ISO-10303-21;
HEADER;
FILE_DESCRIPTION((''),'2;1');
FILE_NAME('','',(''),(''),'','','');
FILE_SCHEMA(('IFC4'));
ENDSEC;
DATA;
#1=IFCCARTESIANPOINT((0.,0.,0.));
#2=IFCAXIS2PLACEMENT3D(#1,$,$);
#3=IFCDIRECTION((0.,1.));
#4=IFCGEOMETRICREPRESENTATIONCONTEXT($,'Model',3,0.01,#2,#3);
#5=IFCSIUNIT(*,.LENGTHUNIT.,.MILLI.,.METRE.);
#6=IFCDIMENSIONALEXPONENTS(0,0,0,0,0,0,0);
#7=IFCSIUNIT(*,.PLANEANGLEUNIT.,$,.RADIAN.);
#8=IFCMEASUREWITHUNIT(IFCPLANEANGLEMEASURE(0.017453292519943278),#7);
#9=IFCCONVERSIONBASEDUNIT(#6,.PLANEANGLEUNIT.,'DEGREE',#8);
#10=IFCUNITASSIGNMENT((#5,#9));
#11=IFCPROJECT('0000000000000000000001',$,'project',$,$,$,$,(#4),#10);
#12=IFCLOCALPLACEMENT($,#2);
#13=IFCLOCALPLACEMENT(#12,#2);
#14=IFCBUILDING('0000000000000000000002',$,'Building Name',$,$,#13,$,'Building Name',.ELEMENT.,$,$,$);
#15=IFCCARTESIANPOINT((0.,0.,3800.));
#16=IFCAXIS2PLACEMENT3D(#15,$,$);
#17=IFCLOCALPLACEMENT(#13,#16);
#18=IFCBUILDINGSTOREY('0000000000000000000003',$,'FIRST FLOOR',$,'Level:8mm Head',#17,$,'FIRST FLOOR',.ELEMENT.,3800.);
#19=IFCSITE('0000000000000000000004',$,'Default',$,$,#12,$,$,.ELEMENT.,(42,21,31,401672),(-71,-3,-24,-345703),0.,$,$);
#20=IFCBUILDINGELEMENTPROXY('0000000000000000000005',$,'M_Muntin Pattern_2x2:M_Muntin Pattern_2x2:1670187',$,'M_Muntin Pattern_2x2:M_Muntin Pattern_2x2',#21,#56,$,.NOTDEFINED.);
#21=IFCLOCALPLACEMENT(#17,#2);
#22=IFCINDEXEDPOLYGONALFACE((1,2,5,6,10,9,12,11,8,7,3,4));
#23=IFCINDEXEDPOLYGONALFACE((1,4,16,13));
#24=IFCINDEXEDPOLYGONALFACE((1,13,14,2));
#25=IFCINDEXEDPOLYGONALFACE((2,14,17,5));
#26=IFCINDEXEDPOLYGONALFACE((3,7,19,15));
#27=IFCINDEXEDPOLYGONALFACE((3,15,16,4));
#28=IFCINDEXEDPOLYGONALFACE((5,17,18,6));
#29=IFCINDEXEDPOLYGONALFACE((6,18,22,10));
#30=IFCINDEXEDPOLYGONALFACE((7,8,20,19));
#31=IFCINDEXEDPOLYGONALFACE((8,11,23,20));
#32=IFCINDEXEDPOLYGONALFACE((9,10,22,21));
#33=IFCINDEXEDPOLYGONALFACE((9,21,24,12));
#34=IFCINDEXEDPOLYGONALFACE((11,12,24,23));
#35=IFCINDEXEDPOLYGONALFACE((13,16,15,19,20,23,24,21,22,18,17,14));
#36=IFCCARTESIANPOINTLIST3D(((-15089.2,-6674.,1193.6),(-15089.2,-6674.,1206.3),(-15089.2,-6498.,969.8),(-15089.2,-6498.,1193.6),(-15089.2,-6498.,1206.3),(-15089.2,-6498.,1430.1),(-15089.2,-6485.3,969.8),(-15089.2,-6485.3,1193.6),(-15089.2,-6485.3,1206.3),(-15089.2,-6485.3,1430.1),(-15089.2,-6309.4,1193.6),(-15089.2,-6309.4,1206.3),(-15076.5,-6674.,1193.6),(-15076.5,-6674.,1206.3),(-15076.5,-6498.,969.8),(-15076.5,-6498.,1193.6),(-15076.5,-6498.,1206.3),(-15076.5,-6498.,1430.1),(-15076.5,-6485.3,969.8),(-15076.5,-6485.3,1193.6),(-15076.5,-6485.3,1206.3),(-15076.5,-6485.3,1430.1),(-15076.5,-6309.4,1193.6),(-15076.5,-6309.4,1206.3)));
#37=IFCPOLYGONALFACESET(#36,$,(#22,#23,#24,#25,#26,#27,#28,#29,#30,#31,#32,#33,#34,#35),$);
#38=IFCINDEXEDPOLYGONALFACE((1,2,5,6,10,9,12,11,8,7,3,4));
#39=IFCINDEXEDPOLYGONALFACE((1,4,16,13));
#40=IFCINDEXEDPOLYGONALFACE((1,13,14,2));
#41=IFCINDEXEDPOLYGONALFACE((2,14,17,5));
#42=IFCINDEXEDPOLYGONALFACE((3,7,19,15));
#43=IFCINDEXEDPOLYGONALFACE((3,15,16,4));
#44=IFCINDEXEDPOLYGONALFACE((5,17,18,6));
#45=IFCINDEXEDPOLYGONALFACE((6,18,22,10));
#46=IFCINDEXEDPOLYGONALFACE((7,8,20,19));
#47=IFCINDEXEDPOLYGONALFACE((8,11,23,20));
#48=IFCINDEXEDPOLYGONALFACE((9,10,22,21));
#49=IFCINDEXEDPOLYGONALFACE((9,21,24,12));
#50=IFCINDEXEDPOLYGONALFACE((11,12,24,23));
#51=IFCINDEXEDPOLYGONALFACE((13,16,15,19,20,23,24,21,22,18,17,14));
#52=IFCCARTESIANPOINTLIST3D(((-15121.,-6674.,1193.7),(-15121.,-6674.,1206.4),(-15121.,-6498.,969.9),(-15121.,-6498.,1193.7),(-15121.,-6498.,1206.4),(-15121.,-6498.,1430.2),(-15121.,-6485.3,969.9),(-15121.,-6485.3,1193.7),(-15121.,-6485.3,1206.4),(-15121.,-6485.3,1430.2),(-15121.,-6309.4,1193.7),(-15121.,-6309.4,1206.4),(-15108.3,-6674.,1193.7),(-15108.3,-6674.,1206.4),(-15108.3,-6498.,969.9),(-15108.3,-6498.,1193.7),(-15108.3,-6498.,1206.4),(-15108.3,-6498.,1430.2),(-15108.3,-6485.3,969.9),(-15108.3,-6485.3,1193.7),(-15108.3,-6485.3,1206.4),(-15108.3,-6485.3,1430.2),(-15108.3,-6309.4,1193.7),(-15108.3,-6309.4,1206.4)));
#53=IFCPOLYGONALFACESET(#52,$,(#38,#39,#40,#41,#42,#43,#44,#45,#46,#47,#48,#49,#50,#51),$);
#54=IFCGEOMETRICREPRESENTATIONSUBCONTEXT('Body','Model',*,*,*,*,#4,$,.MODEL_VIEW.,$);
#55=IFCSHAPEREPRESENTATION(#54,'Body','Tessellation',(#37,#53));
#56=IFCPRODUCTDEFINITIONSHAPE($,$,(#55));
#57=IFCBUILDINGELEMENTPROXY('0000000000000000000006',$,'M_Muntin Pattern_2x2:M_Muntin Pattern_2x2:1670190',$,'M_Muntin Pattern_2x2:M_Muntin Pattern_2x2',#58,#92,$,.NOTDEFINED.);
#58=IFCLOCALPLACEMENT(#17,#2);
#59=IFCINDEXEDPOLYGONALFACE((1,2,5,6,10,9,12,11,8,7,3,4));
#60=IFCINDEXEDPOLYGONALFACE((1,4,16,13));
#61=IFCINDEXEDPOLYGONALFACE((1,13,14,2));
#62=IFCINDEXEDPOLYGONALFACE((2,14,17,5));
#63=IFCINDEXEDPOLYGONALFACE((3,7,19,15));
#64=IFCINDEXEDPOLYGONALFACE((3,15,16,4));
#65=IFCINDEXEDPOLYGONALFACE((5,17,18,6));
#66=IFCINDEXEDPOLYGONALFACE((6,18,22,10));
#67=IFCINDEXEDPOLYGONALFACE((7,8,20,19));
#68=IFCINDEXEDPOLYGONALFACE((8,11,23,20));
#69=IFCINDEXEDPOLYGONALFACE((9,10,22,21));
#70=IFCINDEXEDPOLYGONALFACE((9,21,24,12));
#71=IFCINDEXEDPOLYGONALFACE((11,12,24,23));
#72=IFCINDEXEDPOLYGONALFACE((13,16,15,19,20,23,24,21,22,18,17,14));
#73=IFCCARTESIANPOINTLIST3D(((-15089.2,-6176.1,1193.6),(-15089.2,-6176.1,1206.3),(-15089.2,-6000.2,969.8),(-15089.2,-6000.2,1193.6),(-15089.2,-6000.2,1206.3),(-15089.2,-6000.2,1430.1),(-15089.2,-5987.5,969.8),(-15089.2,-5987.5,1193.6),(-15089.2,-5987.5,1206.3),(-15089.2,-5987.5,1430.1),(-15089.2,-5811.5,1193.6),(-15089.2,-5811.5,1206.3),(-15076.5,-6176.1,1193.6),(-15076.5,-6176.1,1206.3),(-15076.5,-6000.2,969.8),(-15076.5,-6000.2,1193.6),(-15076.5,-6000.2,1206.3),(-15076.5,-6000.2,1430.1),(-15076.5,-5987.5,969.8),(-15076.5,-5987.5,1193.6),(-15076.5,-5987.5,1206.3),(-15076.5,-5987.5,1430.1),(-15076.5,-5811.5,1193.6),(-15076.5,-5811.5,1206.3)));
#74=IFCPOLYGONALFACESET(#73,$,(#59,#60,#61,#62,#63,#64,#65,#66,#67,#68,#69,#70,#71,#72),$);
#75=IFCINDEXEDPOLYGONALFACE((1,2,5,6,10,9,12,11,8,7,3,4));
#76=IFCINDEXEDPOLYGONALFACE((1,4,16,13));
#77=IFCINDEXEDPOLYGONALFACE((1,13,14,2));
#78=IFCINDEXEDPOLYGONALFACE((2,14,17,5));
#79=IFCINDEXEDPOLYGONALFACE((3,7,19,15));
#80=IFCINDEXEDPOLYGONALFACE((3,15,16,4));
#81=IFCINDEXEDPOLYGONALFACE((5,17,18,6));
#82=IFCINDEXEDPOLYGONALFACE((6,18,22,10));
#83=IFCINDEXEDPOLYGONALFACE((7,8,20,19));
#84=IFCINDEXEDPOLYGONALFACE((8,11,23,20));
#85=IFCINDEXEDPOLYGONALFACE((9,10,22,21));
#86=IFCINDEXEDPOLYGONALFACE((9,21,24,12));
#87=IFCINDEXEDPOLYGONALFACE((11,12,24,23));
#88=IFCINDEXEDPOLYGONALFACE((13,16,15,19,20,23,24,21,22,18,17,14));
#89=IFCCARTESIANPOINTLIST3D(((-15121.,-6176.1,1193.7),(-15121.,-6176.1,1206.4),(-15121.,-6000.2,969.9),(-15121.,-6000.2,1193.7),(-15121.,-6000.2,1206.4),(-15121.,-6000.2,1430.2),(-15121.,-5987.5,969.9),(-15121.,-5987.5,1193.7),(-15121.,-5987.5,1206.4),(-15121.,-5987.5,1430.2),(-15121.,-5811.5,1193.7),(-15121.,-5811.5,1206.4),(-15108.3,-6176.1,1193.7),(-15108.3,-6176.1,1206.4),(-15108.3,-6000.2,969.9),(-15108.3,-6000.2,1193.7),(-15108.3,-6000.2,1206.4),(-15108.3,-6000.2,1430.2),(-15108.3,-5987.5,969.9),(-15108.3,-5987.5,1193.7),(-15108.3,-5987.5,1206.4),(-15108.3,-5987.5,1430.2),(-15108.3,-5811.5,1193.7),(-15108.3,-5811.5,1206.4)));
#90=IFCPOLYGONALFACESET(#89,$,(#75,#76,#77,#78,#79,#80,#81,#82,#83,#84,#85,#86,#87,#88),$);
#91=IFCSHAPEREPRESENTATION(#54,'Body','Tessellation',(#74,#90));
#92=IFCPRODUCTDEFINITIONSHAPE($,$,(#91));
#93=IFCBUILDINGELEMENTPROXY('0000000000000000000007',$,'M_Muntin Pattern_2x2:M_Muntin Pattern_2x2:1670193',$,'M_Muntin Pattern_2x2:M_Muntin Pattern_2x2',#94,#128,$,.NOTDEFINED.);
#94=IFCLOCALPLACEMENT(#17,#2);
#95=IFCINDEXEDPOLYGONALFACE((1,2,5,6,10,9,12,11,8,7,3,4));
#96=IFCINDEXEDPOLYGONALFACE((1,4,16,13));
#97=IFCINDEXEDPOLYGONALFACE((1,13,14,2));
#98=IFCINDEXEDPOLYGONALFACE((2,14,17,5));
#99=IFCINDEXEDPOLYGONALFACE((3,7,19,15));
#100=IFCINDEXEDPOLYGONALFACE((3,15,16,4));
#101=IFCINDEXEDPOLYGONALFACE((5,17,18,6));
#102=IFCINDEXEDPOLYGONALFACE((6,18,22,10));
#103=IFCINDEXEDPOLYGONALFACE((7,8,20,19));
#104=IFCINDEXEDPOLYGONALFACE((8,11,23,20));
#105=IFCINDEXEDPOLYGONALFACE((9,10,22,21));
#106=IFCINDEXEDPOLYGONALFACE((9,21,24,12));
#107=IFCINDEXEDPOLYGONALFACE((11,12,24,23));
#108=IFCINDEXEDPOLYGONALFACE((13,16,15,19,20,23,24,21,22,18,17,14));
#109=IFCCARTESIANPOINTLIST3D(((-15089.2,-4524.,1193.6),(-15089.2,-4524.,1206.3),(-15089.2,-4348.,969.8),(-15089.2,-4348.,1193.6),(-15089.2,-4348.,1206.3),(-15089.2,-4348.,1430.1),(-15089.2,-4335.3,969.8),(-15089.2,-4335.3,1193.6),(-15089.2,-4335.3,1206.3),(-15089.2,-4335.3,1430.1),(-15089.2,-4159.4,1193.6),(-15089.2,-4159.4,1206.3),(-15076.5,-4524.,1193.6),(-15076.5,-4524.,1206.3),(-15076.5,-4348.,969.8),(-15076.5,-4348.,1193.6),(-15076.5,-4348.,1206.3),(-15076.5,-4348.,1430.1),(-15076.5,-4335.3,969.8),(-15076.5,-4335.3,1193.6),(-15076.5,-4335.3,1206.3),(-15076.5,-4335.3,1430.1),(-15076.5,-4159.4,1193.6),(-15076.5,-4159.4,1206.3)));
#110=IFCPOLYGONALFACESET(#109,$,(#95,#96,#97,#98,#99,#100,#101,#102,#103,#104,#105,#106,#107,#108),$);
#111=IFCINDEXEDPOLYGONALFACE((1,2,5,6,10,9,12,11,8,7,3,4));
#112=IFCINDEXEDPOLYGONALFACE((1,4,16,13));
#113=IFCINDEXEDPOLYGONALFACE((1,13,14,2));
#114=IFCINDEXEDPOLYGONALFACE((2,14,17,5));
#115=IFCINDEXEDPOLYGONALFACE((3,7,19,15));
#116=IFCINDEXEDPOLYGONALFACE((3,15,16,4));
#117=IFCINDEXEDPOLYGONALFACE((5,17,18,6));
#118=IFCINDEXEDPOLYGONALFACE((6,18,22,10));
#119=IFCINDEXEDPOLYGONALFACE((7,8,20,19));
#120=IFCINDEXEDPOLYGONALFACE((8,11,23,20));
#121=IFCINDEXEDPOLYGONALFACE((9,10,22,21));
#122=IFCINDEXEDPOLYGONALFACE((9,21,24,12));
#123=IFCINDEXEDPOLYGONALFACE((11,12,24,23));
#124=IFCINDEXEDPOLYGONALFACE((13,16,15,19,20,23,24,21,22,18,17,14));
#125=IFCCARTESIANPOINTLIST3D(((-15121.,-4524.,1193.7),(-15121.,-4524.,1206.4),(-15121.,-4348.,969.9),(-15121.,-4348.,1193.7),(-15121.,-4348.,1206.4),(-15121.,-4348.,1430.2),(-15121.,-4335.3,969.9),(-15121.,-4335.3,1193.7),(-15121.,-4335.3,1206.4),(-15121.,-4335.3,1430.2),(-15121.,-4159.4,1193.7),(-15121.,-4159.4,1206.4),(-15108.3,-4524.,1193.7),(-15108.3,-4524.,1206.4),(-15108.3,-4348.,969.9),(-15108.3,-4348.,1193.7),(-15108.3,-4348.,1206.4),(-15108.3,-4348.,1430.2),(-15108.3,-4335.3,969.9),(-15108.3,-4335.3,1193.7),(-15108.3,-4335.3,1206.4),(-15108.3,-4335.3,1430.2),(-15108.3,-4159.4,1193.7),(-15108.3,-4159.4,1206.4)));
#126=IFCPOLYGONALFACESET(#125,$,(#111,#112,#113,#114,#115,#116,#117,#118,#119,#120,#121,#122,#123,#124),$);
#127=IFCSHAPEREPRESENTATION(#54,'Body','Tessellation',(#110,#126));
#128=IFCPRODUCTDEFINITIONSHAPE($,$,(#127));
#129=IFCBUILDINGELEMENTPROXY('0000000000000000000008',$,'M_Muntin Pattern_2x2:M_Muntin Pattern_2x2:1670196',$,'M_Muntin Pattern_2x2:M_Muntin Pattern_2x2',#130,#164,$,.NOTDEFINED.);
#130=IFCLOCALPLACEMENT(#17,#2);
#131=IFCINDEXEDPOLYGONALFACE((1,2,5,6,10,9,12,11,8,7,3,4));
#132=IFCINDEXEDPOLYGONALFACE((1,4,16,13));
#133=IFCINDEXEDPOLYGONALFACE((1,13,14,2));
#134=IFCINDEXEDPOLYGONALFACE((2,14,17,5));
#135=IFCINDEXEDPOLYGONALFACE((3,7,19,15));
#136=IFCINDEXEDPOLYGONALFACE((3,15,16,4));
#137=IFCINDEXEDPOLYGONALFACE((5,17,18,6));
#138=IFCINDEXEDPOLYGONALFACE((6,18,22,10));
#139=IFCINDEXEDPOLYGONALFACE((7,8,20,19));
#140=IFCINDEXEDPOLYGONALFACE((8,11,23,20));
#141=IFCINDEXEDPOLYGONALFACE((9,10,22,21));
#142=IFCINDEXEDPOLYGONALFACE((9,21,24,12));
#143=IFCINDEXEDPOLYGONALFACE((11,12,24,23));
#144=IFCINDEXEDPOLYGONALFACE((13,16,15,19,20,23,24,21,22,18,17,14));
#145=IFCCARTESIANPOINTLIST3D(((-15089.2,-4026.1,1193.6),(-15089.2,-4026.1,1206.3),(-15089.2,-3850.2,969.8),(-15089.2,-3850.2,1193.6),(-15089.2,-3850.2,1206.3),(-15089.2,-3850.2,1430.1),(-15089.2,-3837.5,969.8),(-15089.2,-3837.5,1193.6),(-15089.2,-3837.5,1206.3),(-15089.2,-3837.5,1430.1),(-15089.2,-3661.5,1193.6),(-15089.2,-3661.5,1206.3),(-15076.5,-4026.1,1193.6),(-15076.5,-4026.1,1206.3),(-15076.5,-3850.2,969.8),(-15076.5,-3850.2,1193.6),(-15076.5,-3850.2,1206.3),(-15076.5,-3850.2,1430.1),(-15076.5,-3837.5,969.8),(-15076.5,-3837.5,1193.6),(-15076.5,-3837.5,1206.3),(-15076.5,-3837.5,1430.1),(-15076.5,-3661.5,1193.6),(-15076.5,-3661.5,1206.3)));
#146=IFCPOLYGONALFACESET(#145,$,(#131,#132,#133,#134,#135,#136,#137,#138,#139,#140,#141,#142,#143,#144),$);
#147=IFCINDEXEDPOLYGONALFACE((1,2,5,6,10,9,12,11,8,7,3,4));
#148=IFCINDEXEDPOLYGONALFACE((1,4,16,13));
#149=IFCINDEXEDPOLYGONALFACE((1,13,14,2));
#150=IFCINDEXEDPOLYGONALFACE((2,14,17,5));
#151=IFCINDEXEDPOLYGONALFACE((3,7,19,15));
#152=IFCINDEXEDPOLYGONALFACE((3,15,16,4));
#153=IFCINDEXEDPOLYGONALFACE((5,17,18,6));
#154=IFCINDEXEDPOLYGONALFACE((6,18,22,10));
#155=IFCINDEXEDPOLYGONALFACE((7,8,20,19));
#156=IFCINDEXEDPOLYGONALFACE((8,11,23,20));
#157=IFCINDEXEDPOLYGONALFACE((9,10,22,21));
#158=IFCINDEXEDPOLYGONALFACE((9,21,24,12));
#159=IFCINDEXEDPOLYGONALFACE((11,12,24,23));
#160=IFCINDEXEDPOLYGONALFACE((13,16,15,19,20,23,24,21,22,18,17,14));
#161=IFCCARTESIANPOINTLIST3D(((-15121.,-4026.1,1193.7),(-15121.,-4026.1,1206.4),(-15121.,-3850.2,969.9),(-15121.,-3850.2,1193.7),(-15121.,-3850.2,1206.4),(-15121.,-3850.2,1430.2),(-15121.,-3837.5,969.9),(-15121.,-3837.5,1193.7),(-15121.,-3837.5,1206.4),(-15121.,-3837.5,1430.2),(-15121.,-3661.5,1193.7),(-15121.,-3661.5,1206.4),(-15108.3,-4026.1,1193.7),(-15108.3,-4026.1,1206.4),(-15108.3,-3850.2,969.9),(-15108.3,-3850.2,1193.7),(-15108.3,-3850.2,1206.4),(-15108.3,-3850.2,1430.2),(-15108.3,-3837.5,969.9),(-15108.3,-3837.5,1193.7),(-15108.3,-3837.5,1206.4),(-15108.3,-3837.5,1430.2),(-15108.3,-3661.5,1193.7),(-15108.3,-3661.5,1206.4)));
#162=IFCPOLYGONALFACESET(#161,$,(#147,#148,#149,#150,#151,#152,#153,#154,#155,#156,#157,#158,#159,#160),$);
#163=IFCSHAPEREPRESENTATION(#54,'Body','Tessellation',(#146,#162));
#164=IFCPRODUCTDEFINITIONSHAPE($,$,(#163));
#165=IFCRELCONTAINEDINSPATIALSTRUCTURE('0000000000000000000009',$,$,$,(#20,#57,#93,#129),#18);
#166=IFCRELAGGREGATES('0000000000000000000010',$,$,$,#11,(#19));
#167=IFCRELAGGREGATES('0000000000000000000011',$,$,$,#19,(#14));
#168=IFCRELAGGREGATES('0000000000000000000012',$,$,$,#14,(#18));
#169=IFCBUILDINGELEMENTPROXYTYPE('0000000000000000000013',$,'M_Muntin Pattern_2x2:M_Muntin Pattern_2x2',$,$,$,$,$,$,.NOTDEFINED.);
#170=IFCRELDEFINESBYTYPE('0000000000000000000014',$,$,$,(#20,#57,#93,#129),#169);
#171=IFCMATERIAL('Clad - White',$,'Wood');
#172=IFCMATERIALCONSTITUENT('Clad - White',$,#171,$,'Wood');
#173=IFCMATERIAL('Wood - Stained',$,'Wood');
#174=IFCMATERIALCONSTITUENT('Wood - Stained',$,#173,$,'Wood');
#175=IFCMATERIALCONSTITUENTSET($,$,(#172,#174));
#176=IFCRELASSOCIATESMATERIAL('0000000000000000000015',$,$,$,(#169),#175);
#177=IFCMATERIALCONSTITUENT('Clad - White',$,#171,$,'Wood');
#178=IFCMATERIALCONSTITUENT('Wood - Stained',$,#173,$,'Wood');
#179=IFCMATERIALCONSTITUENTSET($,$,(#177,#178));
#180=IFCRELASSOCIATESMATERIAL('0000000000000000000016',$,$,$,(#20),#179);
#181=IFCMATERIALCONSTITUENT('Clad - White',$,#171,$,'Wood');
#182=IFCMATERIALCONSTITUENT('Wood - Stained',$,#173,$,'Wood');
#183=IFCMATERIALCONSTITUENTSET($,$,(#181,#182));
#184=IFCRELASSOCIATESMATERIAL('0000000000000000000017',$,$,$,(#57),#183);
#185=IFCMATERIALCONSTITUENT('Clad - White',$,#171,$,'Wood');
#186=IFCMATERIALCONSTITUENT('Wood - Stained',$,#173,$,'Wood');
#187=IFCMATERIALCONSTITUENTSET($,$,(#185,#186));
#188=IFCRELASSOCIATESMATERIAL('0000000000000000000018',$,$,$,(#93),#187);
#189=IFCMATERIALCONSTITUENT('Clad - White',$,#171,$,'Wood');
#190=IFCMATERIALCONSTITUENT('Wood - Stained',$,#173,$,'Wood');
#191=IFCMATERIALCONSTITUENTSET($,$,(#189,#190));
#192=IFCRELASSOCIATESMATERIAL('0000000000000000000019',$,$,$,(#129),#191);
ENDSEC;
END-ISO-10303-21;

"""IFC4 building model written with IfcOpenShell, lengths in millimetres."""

from ifc_helpers import new_model, entity, si_unit, converted_unit, direction, frame, origin, place, context, subcontext, project, spatial, indexed_curve, outline, extrude, source, transform, mapped, material, constituent, constituent_set, type_object, type_shapes, element, save


model = new_model("IFC4")

# Units and contexts
model_context = context("Model", 3, precision=0.01, world=origin(), true_north=direction((0.0, 1.0)))
body_context = subcontext(model_context, "Body", "Model", "MODEL_VIEW")
ifc_project = project(units=[si_unit("LENGTHUNIT", "METRE", prefix="MILLI"), converted_unit("PLANEANGLEUNIT", "DEGREE", entity("IfcPlaneAngleMeasure", 0.017453292519943278), si_unit("PLANEANGLEUNIT", "RADIAN"), dimensions=[0, 0, 0, 0, 0, 0, 0])], contexts=[model_context])

# Site, building, storey
site_placement = place(None, origin())
site = spatial("IfcSite", under=ifc_project, at=site_placement, Name="Default", CompositionType="ELEMENT", RefLatitude=(42, 21, 31, 401672), RefLongitude=(-71, -3, -24, -345703), RefElevation=0.0)
building_placement = place(site_placement, origin())
building = spatial("IfcBuilding", under=site, at=building_placement, Name="Building Name", LongName="Building Name", CompositionType="ELEMENT")
storey_placement = place(building_placement, frame((0.0, 0.0, 3800.0)))
storey = spatial("IfcBuildingStorey", under=building, at=storey_placement, Name="FIRST FLOOR", ObjectType="Level:8mm Head", LongName="FIRST FLOOR", CompositionType="ELEMENT", Elevation=3800.0)

# Shared definitions
ifc_material_1 = material(Name="Wood - Stained", Category="Wood")

# Building element proxies
ifc_material_2 = material(Name="Clad - White", Category="Wood")
ifc_constituent_1 = constituent(ifc_material_2, Name="Clad - White", Category="Wood")
ifc_constituent_2 = constituent(ifc_material_1, Name="Wood - Stained", Category="Wood")
ifc_constituent_set_1 = constituent_set(constituents=[ifc_constituent_1, ifc_constituent_2])
ifc_constituent_3 = constituent(ifc_material_2, Name="Clad - White", Category="Wood")
ifc_constituent_4 = constituent(ifc_material_1, Name="Wood - Stained", Category="Wood")
ifc_constituent_set_2 = constituent_set(constituents=[ifc_constituent_3, ifc_constituent_4])
building_element_proxy_type_1 = type_object("IfcBuildingElementProxyType", Name="M_Muntin Pattern_2x2:M_Muntin Pattern_2x2", PredefinedType="NOTDEFINED", material=ifc_constituent_set_2)
shared_shape_1 = source(origin(), body_context, "Body", "SweptSolid", [
    extrude(outline(indexed_curve([(6.4, -6.4), (230.1, -6.4), (230.1, 6.3), (6.4, 6.3), (6.4, 182.3), (-6.3, 182.3), (-6.3, 6.3), (-230.2, 6.3), (-230.2, -6.4), (-6.3, -6.4), (-6.3, -182.3), (6.4, -182.3), (6.4, -6.4)], self_intersect=False)), frame((0.0, -22.2, 230.1), z_axis=(0.0, 1.0, 0.0), x_axis=(0.0, 0.0, 1.0)), (0.0, 0.0, 1.0), 12.7),
    extrude(outline(indexed_curve([(6.4, -6.4), (230.2, -6.4), (230.2, 6.3), (6.4, 6.3), (6.4, 182.3), (-6.3, 182.3), (-6.3, 6.3), (-230.2, 6.3), (-230.2, -6.4), (-6.3, -6.4), (-6.3, -182.3), (6.4, -182.3), (6.4, -6.4)], self_intersect=False)), frame((0.0, 9.5, 230.2), z_axis=(0.0, 1.0, 0.0), x_axis=(0.0, 0.0, 1.0)), (0.0, 0.0, 1.0), 12.7),
])
type_shapes(building_element_proxy_type_1, [shared_shape_1])
proxy_1_placement = place(storey_placement, frame((-15098.7, -6491.7, 969.9), z_axis=(0.0, 0.0, 1.0), x_axis=(0.0, 1.0, 0.0)))
element("IfcBuildingElementProxy", 1, at=proxy_1_placement, inside=storey, type_object=building_element_proxy_type_1, material=ifc_constituent_set_1, Name="M_Muntin Pattern_2x2:M_Muntin Pattern_2x2:1670187", ObjectType="M_Muntin Pattern_2x2:M_Muntin Pattern_2x2", PredefinedType="NOTDEFINED", context=body_context, shape_type="MappedRepresentation", body=[
    mapped(shared_shape_1, transform((0.0, 0.0, 0.0), scale=1.0)),
])
ifc_constituent_5 = constituent(ifc_material_2, Name="Clad - White", Category="Wood")
ifc_constituent_6 = constituent(ifc_material_1, Name="Wood - Stained", Category="Wood")
ifc_constituent_set_3 = constituent_set(constituents=[ifc_constituent_5, ifc_constituent_6])
proxy_2_placement = place(storey_placement, frame((-15098.7, -5993.8, 969.9), z_axis=(0.0, 0.0, 1.0), x_axis=(0.0, 1.0, 0.0)))
element("IfcBuildingElementProxy", 2, at=proxy_2_placement, inside=storey, type_object=building_element_proxy_type_1, material=ifc_constituent_set_3, Name="M_Muntin Pattern_2x2:M_Muntin Pattern_2x2:1670190", ObjectType="M_Muntin Pattern_2x2:M_Muntin Pattern_2x2", PredefinedType="NOTDEFINED", context=body_context, shape_type="MappedRepresentation", body=[
    mapped(shared_shape_1, transform((0.0, 0.0, 0.0), scale=1.0)),
])
ifc_constituent_7 = constituent(ifc_material_2, Name="Clad - White", Category="Wood")
ifc_constituent_8 = constituent(ifc_material_1, Name="Wood - Stained", Category="Wood")
ifc_constituent_set_4 = constituent_set(constituents=[ifc_constituent_7, ifc_constituent_8])
proxy_3_placement = place(storey_placement, frame((-15098.7, -4341.7, 969.9), z_axis=(0.0, 0.0, 1.0), x_axis=(0.0, 1.0, 0.0)))
element("IfcBuildingElementProxy", 3, at=proxy_3_placement, inside=storey, type_object=building_element_proxy_type_1, material=ifc_constituent_set_4, Name="M_Muntin Pattern_2x2:M_Muntin Pattern_2x2:1670193", ObjectType="M_Muntin Pattern_2x2:M_Muntin Pattern_2x2", PredefinedType="NOTDEFINED", context=body_context, shape_type="MappedRepresentation", body=[
    mapped(shared_shape_1, transform((0.0, 0.0, 0.0), scale=1.0)),
])
ifc_constituent_9 = constituent(ifc_material_2, Name="Clad - White", Category="Wood")
ifc_constituent_10 = constituent(ifc_material_1, Name="Wood - Stained", Category="Wood")
ifc_constituent_set_5 = constituent_set(constituents=[ifc_constituent_9, ifc_constituent_10])
proxy_4_placement = place(storey_placement, frame((-15098.7, -3843.8, 969.9), z_axis=(0.0, 0.0, 1.0), x_axis=(0.0, 1.0, 0.0)))
element("IfcBuildingElementProxy", 4, at=proxy_4_placement, inside=storey, type_object=building_element_proxy_type_1, material=ifc_constituent_set_5, Name="M_Muntin Pattern_2x2:M_Muntin Pattern_2x2:1670196", ObjectType="M_Muntin Pattern_2x2:M_Muntin Pattern_2x2", PredefinedType="NOTDEFINED", context=body_context, shape_type="MappedRepresentation", body=[
    mapped(shared_shape_1, transform((0.0, 0.0, 0.0), scale=1.0)),
])

save(model, "model.ifc")
